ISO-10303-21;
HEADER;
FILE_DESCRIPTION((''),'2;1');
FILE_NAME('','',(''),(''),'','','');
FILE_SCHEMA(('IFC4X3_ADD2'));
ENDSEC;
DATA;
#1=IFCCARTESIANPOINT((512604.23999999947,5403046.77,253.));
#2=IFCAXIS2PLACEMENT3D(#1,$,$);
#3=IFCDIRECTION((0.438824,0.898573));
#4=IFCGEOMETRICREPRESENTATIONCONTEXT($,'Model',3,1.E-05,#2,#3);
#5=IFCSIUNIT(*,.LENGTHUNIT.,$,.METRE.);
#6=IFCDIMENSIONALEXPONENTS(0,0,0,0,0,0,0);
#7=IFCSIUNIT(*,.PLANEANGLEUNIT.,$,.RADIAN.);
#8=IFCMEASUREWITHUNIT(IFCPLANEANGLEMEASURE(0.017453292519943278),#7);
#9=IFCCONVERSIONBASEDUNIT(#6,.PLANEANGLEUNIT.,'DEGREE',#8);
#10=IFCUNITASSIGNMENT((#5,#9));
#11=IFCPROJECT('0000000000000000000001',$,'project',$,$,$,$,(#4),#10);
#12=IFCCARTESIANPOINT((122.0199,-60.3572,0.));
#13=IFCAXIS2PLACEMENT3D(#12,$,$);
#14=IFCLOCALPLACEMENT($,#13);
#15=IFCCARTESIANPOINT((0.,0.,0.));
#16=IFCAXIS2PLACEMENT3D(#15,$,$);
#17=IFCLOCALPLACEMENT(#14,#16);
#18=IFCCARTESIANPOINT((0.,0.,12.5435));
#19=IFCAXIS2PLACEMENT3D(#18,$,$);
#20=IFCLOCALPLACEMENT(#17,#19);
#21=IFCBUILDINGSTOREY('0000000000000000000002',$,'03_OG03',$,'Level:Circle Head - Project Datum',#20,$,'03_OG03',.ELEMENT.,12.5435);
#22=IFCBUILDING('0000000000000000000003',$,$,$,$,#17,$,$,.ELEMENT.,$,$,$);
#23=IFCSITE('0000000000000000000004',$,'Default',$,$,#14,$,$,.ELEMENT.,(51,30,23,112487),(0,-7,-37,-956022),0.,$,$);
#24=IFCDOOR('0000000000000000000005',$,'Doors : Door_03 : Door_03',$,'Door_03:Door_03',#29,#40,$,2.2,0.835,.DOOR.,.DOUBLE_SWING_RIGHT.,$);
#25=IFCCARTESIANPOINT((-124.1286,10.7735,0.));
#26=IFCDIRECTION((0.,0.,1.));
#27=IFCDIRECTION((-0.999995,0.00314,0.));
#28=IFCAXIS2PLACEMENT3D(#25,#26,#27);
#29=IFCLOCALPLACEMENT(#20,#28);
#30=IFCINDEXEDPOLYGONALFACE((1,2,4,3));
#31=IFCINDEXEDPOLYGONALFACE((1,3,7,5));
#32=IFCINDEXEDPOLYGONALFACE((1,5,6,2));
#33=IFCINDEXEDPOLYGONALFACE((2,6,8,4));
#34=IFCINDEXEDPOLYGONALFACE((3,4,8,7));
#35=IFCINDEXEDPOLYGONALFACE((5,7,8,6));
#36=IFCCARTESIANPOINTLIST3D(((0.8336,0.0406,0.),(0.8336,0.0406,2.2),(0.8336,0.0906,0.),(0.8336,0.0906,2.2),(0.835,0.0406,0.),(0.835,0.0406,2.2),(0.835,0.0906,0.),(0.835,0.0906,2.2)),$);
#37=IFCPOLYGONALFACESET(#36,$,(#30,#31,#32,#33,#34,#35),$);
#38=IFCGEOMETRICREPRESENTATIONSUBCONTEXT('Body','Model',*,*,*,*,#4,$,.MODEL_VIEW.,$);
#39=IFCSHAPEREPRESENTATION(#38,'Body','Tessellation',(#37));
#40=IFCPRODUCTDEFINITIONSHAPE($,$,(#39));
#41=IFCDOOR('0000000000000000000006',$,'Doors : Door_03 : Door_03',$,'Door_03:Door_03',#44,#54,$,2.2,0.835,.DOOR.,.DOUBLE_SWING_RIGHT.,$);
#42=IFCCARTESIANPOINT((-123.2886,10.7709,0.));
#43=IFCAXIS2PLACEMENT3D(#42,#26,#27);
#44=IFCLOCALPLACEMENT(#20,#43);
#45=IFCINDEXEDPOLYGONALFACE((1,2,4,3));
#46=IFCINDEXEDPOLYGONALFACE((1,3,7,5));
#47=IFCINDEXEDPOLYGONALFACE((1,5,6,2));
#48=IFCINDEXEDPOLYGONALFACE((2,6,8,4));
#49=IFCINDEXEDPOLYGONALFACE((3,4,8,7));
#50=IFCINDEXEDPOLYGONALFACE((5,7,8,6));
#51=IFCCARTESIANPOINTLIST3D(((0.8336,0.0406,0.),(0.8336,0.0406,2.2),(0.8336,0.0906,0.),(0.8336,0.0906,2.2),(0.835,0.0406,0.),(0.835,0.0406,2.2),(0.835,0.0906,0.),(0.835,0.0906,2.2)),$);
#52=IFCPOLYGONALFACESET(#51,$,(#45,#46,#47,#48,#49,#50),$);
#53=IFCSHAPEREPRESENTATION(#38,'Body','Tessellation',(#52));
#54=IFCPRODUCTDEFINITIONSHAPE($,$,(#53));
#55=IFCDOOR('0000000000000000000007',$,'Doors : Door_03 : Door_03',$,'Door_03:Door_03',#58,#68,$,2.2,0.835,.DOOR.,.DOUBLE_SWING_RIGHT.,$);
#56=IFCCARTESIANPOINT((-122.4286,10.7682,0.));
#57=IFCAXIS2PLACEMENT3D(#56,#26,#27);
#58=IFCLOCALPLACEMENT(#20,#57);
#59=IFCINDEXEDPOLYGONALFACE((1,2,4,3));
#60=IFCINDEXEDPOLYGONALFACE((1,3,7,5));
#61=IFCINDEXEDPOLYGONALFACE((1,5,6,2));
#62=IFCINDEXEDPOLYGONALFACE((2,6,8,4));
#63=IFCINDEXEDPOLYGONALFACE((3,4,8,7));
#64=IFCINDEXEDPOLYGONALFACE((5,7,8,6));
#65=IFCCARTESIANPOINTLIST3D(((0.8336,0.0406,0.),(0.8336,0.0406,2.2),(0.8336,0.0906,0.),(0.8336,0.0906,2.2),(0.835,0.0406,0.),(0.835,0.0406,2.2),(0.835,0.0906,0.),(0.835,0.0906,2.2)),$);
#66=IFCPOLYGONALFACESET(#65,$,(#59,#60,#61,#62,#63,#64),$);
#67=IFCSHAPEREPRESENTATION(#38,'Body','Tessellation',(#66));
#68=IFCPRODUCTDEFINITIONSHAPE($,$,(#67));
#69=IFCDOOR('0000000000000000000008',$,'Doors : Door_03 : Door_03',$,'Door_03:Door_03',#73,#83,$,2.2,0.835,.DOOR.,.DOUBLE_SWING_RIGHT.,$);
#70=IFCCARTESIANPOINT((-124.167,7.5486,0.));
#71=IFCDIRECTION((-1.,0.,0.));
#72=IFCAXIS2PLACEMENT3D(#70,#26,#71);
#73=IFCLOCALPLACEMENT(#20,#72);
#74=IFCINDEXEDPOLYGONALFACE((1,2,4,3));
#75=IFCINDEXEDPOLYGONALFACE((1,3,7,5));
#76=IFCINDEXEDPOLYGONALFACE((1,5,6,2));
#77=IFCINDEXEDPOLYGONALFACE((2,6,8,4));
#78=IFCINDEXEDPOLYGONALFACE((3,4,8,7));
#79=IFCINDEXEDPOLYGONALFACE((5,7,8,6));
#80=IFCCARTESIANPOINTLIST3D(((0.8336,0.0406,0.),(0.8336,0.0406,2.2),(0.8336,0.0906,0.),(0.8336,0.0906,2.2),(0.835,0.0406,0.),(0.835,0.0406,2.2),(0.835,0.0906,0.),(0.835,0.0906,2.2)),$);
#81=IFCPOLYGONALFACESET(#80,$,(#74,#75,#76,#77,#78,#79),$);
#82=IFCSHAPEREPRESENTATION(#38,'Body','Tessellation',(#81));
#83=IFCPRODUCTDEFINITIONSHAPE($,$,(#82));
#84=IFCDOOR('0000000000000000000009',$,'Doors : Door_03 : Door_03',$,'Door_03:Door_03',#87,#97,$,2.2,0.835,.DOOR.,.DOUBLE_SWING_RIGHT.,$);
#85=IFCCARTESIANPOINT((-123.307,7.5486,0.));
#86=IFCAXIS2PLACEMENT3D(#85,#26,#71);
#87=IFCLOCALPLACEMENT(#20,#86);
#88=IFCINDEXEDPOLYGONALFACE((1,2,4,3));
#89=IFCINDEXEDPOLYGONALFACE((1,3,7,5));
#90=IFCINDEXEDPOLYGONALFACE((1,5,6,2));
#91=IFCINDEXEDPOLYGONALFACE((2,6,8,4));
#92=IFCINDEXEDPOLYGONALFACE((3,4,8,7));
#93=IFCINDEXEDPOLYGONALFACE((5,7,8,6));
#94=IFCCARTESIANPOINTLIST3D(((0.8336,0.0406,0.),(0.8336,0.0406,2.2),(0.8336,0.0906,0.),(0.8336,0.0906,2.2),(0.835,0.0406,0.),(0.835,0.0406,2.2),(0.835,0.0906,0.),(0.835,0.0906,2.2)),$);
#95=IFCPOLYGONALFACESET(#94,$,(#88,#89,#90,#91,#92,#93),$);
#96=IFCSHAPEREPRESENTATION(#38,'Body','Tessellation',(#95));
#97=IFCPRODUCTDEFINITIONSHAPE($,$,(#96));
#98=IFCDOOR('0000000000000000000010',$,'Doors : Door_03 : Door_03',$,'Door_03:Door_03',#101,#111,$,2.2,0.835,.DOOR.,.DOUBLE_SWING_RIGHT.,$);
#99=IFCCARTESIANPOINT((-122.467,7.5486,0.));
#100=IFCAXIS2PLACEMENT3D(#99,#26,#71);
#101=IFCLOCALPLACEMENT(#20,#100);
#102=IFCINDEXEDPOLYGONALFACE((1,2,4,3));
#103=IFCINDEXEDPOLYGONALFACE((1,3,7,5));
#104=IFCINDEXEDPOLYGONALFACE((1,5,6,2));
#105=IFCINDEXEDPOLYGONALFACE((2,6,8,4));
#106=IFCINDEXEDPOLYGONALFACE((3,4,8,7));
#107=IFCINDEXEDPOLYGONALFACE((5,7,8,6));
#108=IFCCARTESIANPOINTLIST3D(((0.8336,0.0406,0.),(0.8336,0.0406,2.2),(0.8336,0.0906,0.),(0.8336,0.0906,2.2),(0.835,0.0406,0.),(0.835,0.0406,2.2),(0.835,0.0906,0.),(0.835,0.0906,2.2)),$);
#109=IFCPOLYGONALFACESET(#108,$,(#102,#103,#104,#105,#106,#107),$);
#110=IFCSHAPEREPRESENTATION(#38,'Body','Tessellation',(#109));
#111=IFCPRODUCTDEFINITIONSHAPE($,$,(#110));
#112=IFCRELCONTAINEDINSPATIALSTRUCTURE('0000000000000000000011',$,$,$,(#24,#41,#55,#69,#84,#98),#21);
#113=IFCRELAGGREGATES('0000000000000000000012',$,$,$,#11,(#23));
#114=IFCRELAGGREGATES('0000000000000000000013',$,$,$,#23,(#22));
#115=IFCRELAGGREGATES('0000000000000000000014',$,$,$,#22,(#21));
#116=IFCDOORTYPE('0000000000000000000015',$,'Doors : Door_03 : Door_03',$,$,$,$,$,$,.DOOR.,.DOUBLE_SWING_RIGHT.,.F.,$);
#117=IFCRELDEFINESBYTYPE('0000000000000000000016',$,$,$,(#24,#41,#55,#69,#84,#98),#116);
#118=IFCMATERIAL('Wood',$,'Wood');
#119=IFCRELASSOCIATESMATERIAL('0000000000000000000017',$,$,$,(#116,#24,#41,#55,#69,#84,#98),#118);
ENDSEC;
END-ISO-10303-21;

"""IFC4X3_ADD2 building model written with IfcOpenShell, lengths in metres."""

from ifc_helpers import new_model, entity, si_unit, converted_unit, direction, frame, origin, origin_2d_with_axis, place, context, subcontext, project, spatial, rectangle, extrude, source, transform, mapped, material, type_object, type_shapes, element, save


model = new_model("IFC4X3_ADD2")

# Units and contexts
model_context = context("Model", 3, precision=1e-05, world=frame((512604.23999999947, 5403046.77, 253.0)), true_north=direction((0.438824, 0.898573)))
body_context = subcontext(model_context, "Body", "Model", "MODEL_VIEW")
ifc_project = project(units=[si_unit("LENGTHUNIT", "METRE"), converted_unit("PLANEANGLEUNIT", "DEGREE", entity("IfcPlaneAngleMeasure", 0.017453292519943278), si_unit("PLANEANGLEUNIT", "RADIAN"), dimensions=[0, 0, 0, 0, 0, 0, 0])], contexts=[model_context])

# Site, building, storey
site_placement = place(None, frame((122.0199, -60.3572, 0.0)))
site = spatial("IfcSite", under=ifc_project, at=site_placement, Name="Default", CompositionType="ELEMENT", RefLatitude=(51, 30, 23, 112487), RefLongitude=(0, -7, -37, -956022), RefElevation=0.0)
building_placement = place(site_placement, origin())
building = spatial("IfcBuilding", under=site, at=building_placement, CompositionType="ELEMENT")
storey_placement = place(building_placement, frame((0.0, 0.0, 12.5435)))
storey = spatial("IfcBuildingStorey", under=building, at=storey_placement, Name="03_OG03", ObjectType="Level:Circle Head - Project Datum", LongName="03_OG03", CompositionType="ELEMENT", Elevation=12.5435)

# Doors
ifc_material_1 = material(Name="Wood", Category="Wood")
door_type = type_object("IfcDoorType", Name="Doors : Door_03 : Door_03", OperationType="DOUBLE_SWING_RIGHT", ParameterTakesPrecedence=False, PredefinedType="DOOR", material=ifc_material_1)
shared_shape_1 = source(origin(), body_context, "Body", "SweptSolid", [
    extrude(rectangle(XDim=0.0014, YDim=0.05, at=origin_2d_with_axis()), frame((0.8343, 0.0656, 0.0), z_axis=(0.0, 0.0, 1.0), x_axis=(-1.0, 0.0, 0.0)), (0.0, 0.0, 1.0), 2.2),
])
type_shapes(door_type, [shared_shape_1])
for number, where, z_axis, x_axis, name in (
    (1, (-124.1286, 10.7735, 0.0), (0.0, 0.0, 1.0), (-0.999995, 0.00314, 0.0), "Doors : Door_03 : Door_03"),
    (2, (-123.2886, 10.7709, 0.0), (0.0, 0.0, 1.0), (-0.999995, 0.00314, 0.0), "Doors : Door_03 : Door_03"),
    (3, (-122.4286, 10.7682, 0.0), (0.0, 0.0, 1.0), (-0.999995, 0.00314, 0.0), "Doors : Door_03 : Door_03"),
    (4, (-124.167, 7.5486, 0.0), (0.0, 0.0, 1.0), (-1.0, 0.0, 0.0), "Doors : Door_03 : Door_03"),
    (5, (-123.307, 7.5486, 0.0), (0.0, 0.0, 1.0), (-1.0, 0.0, 0.0), "Doors : Door_03 : Door_03"),
    (6, (-122.467, 7.5486, 0.0), (0.0, 0.0, 1.0), (-1.0, 0.0, 0.0), "Doors : Door_03 : Door_03"),
):
    element("IfcDoor", number, at=place(storey_placement, frame(where, z_axis=z_axis, x_axis=x_axis)), inside=storey, type_object=door_type, material=ifc_material_1, Name=name, ObjectType="Door_03:Door_03", OperationType="DOUBLE_SWING_RIGHT", OverallHeight=2.2, OverallWidth=0.835, PredefinedType="DOOR", context=body_context, shape_type="MappedRepresentation", body=[
        mapped(shared_shape_1, transform((0.0, 0.0, 0.0), scale=1.0)),
    ])

save(model, "model.ifc")
